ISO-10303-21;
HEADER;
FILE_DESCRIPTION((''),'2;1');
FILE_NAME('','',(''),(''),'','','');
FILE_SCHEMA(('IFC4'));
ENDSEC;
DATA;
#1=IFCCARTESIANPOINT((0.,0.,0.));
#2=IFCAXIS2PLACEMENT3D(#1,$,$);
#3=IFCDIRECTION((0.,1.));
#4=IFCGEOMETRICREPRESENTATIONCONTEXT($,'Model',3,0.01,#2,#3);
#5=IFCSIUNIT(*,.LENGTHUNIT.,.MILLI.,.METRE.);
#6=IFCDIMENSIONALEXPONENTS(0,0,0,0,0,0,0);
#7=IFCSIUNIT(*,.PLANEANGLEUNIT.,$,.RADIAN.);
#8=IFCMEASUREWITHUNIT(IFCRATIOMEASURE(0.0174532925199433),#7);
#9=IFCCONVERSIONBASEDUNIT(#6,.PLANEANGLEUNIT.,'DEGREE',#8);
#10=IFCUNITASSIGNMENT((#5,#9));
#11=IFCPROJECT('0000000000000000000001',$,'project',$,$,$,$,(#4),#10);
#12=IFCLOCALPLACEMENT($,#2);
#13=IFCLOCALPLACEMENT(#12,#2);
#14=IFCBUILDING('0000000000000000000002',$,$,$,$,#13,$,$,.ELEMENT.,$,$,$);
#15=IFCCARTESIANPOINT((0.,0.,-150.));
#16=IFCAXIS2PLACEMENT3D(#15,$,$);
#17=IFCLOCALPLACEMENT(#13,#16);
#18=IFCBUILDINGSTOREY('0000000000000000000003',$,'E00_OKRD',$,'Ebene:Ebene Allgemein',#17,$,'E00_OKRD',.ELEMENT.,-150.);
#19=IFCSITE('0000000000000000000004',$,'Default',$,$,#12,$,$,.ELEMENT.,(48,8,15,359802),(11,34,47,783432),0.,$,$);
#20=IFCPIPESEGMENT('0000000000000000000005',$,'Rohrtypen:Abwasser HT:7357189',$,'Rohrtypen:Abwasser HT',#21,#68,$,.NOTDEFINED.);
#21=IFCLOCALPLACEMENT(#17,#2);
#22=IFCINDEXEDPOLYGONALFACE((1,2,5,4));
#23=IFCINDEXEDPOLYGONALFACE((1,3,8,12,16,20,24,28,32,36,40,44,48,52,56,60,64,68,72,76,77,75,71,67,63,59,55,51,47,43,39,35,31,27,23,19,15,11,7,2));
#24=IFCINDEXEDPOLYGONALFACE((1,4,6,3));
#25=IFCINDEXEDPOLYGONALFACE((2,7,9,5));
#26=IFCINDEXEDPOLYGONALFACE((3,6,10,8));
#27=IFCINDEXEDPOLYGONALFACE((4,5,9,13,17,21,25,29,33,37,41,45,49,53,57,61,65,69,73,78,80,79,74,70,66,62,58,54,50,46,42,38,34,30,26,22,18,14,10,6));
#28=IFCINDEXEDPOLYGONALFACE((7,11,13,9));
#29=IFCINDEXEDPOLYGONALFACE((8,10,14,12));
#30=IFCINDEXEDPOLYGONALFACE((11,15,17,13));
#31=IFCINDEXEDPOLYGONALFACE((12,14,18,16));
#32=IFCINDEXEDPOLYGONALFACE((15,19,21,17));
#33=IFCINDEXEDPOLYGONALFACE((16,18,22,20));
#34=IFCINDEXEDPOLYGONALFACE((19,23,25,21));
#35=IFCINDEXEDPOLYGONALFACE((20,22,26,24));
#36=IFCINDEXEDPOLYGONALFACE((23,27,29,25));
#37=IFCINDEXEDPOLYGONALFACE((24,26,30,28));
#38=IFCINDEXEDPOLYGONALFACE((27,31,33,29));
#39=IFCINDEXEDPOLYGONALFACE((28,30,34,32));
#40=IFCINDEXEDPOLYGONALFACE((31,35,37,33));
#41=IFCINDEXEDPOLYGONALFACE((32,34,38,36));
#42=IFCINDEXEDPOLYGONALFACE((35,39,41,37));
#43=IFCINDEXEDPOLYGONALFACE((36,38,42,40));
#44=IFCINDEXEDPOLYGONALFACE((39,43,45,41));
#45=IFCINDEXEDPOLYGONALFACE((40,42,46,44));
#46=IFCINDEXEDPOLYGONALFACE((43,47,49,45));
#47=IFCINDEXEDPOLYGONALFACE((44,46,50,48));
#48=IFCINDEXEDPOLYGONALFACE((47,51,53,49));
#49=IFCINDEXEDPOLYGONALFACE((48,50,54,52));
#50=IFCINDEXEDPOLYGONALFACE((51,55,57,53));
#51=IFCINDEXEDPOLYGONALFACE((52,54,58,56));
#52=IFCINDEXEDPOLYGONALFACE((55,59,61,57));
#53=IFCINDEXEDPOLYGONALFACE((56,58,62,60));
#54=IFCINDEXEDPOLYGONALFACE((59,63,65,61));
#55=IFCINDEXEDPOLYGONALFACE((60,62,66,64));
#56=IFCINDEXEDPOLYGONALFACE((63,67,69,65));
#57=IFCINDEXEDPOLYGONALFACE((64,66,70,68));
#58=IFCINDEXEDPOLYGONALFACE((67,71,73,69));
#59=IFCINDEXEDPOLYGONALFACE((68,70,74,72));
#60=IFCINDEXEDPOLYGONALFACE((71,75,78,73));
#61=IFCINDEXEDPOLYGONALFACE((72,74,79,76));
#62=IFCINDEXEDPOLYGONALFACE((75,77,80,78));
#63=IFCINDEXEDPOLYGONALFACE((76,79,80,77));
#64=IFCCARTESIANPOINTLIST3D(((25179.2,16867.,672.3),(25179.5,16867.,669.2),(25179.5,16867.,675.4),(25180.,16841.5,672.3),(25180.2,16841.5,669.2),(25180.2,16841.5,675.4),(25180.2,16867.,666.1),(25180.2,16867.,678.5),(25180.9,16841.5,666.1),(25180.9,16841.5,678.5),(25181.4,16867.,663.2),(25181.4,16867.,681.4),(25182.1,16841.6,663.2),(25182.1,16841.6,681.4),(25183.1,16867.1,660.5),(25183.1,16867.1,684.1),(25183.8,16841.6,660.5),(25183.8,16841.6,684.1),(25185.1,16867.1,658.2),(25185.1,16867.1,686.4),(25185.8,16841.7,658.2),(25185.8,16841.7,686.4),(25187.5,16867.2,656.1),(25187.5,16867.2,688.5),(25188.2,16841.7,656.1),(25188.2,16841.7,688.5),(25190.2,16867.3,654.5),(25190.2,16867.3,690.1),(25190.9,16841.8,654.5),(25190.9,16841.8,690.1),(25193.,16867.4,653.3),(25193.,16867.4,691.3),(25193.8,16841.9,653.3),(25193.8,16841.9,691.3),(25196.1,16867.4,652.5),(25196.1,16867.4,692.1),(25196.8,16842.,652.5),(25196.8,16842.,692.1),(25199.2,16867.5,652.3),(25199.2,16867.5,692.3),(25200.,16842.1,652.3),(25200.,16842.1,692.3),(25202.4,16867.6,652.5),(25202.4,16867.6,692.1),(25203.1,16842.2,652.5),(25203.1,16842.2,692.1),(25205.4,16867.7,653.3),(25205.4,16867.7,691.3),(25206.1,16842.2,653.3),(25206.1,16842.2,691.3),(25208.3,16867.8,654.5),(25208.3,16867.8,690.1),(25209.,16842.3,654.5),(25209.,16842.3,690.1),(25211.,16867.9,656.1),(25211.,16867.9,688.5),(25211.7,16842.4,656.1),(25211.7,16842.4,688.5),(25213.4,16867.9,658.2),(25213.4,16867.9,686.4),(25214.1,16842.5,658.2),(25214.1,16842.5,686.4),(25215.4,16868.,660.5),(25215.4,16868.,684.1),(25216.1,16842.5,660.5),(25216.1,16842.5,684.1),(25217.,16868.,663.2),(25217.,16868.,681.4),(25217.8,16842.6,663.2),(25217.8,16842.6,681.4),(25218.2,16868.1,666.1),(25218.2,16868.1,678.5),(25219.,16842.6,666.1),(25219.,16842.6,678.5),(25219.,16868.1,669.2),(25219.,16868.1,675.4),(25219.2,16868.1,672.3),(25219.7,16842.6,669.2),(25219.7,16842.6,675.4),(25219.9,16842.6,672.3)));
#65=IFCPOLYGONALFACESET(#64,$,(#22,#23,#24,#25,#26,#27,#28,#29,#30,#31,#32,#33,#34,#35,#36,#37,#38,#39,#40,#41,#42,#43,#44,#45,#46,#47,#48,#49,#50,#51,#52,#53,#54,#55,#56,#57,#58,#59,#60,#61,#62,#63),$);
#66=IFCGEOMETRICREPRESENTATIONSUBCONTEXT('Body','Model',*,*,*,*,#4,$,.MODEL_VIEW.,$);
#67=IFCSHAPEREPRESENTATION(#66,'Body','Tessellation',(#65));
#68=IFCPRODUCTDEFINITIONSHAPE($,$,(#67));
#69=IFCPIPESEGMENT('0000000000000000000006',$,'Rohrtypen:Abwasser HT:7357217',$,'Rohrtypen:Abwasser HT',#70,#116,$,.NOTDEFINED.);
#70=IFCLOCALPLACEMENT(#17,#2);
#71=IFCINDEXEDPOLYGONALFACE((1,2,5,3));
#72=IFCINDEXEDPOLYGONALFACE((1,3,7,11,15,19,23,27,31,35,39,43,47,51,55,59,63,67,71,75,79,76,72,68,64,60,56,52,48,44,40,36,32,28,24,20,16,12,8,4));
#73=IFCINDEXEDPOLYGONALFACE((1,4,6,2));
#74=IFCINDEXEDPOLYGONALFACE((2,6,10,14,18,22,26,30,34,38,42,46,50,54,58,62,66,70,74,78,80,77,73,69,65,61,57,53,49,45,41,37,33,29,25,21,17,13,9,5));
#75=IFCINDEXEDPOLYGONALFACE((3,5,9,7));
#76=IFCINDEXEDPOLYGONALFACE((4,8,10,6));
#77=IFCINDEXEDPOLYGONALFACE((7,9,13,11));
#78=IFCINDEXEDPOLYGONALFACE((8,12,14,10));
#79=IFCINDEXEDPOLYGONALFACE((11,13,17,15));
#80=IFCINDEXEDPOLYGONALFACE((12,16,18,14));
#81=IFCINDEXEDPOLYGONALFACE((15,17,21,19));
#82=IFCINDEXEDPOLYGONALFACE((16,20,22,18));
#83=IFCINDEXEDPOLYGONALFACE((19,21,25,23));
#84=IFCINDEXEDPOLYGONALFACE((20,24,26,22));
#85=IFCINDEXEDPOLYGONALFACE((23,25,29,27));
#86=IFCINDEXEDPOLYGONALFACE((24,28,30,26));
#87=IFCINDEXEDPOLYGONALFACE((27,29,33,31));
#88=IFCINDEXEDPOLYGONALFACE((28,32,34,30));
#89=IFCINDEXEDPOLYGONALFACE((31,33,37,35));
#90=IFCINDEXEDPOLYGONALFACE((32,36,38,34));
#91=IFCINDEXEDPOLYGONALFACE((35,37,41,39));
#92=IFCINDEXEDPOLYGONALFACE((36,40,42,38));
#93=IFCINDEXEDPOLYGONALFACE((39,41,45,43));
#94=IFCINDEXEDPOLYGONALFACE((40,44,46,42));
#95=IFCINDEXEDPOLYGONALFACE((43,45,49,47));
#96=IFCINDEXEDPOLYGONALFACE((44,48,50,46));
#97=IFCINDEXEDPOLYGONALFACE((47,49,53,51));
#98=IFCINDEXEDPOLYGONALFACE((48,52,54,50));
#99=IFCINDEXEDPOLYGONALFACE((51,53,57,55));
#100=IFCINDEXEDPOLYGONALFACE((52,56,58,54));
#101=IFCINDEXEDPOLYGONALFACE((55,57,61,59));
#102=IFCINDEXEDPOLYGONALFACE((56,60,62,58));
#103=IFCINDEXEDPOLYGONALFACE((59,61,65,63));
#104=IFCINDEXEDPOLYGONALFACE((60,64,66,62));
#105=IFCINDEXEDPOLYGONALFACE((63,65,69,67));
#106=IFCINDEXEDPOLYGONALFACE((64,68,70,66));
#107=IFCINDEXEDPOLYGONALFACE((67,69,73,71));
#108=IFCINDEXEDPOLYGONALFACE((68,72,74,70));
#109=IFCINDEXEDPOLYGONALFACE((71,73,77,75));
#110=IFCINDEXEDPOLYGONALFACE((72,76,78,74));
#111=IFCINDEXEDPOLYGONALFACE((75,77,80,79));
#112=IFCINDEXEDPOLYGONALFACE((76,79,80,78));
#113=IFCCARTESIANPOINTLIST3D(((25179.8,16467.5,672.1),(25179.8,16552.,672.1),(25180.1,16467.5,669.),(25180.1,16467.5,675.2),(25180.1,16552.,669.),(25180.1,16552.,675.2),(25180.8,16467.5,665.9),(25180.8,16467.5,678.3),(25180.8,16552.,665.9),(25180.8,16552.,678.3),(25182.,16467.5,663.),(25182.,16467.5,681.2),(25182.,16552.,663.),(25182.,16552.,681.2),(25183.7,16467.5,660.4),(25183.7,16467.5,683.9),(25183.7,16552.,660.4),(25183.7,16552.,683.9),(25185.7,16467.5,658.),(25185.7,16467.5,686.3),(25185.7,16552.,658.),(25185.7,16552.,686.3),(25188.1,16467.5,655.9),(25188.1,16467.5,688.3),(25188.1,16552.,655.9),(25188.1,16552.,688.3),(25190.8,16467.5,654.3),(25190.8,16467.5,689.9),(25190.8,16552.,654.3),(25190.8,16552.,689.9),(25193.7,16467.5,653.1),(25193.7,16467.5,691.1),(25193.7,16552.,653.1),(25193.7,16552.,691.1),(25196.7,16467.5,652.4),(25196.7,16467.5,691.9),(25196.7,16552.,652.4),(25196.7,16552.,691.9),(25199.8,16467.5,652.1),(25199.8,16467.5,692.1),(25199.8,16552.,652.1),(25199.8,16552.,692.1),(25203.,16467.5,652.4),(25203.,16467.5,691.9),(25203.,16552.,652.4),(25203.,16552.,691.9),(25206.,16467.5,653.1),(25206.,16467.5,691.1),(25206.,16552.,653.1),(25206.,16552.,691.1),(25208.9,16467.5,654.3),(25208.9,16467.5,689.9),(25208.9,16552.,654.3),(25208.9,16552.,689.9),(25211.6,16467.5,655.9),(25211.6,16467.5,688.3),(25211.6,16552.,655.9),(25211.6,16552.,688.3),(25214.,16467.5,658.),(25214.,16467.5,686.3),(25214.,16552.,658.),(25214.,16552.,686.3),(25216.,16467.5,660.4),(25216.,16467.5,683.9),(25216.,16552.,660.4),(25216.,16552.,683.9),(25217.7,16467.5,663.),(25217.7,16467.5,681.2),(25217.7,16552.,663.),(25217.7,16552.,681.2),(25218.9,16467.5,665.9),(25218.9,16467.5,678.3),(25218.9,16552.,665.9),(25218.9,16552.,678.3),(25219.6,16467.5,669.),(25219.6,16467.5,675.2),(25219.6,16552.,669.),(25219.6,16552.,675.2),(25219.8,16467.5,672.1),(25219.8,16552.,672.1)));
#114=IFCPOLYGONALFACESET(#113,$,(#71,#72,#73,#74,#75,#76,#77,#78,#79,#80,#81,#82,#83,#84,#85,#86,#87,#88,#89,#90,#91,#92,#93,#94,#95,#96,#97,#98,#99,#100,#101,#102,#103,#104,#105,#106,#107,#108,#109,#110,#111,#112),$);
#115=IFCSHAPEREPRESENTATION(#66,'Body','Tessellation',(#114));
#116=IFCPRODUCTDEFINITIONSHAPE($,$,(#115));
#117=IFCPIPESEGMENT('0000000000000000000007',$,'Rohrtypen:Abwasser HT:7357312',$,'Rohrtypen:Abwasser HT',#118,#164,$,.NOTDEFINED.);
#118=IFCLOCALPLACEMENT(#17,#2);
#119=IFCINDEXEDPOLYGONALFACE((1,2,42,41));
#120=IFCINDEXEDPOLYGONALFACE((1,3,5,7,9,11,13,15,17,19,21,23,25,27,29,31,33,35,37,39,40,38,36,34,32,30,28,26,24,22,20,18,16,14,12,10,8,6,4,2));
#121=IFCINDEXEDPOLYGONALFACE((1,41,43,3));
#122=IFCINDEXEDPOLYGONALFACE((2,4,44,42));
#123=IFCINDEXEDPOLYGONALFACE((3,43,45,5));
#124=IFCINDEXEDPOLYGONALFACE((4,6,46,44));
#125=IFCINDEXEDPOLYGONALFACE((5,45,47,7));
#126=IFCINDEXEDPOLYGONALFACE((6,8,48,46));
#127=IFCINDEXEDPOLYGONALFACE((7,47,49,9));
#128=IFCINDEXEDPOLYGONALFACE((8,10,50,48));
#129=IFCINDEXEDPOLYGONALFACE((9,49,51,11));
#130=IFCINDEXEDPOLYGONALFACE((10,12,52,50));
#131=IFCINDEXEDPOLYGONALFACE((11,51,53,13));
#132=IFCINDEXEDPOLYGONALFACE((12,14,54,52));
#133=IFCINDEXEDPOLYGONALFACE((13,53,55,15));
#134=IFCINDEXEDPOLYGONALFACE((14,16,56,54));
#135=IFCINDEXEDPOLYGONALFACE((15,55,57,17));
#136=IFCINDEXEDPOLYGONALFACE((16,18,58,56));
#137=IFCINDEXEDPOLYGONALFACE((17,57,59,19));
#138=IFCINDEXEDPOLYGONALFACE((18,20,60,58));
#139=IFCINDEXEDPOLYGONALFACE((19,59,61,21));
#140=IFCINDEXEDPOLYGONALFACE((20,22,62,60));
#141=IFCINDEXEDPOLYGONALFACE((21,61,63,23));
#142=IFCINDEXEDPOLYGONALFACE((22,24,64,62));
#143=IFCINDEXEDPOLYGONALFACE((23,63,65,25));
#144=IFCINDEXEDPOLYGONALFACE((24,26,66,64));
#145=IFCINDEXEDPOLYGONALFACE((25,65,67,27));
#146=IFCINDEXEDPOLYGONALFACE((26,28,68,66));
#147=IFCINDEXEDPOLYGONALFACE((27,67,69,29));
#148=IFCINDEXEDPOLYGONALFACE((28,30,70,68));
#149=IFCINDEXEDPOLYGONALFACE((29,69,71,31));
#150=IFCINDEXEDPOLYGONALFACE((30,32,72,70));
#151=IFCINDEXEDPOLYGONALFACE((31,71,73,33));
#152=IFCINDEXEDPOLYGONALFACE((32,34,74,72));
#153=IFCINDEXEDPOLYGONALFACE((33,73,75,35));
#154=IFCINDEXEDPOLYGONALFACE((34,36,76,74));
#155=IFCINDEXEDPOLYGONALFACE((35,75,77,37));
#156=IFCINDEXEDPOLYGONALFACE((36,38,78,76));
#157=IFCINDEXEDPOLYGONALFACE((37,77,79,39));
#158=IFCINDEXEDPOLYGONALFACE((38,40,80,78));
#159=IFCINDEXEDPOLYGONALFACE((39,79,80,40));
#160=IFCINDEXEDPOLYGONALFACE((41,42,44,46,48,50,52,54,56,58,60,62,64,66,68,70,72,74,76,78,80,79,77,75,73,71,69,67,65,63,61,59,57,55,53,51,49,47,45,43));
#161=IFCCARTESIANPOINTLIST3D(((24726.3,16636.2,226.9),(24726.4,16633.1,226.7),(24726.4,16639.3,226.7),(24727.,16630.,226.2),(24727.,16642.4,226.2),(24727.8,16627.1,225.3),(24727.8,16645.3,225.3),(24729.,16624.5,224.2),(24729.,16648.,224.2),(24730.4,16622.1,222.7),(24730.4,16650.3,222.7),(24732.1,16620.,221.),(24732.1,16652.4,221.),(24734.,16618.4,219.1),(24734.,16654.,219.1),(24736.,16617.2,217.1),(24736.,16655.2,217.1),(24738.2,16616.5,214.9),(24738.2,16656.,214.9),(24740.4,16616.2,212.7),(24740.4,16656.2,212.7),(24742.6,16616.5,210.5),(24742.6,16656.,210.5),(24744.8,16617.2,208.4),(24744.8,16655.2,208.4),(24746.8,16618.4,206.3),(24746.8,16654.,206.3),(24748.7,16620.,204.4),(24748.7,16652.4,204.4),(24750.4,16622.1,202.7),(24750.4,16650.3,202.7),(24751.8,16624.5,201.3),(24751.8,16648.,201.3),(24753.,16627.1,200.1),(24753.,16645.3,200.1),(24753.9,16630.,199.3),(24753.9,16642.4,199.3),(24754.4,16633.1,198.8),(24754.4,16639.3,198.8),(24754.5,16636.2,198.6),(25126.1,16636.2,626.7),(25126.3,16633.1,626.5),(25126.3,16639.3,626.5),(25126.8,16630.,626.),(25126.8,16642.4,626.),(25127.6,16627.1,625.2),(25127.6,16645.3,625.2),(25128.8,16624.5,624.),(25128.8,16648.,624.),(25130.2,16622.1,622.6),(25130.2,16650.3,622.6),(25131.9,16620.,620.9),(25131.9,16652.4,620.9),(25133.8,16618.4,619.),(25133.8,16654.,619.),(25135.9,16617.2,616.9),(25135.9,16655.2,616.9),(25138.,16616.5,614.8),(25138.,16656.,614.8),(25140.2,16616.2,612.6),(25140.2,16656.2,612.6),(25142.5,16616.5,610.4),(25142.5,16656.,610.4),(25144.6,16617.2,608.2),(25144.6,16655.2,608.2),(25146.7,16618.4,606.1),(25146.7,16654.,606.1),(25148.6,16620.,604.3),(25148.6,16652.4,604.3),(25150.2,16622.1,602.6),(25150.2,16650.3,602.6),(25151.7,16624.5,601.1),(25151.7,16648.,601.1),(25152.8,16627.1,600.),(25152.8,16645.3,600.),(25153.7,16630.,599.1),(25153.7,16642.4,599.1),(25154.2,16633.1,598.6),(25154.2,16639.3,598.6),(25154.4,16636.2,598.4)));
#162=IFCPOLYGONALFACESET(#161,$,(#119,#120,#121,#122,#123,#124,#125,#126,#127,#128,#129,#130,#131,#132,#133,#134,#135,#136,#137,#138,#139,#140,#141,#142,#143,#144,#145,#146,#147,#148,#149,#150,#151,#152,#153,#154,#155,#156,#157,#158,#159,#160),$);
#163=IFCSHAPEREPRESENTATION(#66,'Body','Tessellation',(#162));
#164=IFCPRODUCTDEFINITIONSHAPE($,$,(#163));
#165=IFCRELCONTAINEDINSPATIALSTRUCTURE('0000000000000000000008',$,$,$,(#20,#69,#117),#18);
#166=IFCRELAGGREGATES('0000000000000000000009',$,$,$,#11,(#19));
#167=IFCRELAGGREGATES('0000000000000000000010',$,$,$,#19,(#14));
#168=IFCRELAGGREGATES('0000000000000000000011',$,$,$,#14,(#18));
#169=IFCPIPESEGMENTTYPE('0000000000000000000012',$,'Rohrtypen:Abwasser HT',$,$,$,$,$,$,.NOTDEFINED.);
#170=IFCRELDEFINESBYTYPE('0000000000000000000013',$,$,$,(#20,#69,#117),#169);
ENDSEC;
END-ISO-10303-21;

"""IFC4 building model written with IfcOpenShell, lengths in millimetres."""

from ifc_helpers import new_model, entity, si_unit, converted_unit, direction, frame, origin, place, context, subcontext, project, spatial, indexed_curve, outline, extrude, type_object, element, save


model = new_model("IFC4")

# Units and contexts
model_context = context("Model", 3, precision=0.01, world=origin(), true_north=direction((0.0, 1.0)))
body_context = subcontext(model_context, "Body", "Model", "MODEL_VIEW")
ifc_project = project(units=[si_unit("LENGTHUNIT", "METRE", prefix="MILLI"), converted_unit("PLANEANGLEUNIT", "DEGREE", entity("IfcRatioMeasure", 0.0174532925199433), si_unit("PLANEANGLEUNIT", "RADIAN"), dimensions=[0, 0, 0, 0, 0, 0, 0])], contexts=[model_context])

# Site, building, storey
site_placement = place(None, origin())
site = spatial("IfcSite", under=ifc_project, at=site_placement, Name="Default", CompositionType="ELEMENT", RefLatitude=(48, 8, 15, 359802), RefLongitude=(11, 34, 47, 783432), RefElevation=0.0)
building_placement = place(site_placement, origin())
building = spatial("IfcBuilding", under=site, at=building_placement, CompositionType="ELEMENT")
storey_placement = place(building_placement, frame((0.0, 0.0, -150.0)))
storey = spatial("IfcBuildingStorey", under=building, at=storey_placement, Name="E00_OKRD", ObjectType="Ebene:Ebene Allgemein", LongName="E00_OKRD", CompositionType="ELEMENT", Elevation=-150.0)

# Pipe segments
pipe_segment_type_1 = type_object("IfcPipeSegmentType", Name="Rohrtypen:Abwasser HT", PredefinedType="NOTDEFINED")
pipe_segment_1_placement = place(storey_placement, origin())
element("IfcPipeSegment", 1, at=pipe_segment_1_placement, inside=storey, type_object=pipe_segment_type_1, Name="Rohrtypen:Abwasser HT:7357189", ObjectType="Rohrtypen:Abwasser HT", PredefinedType="NOTDEFINED", context=body_context, shape_type="SweptSolid", body=[
    extrude(outline(indexed_curve([(20.0, 0.0), (19.8, 3.1), (19.0, 6.2), (17.8, 9.1), (16.2, 11.8), (14.1, 14.1), (11.8, 16.2), (9.1, 17.8), (6.2, 19.0), (3.1, 19.8), (0.0, 20.0), (-3.1, 19.8), (-6.2, 19.0), (-9.1, 17.8), (-11.8, 16.2), (-14.1, 14.1), (-16.2, 11.8), (-17.8, 9.1), (-19.0, 6.2), (-19.8, 3.1), (-20.0, 0.0), (-19.8, -3.1), (-19.0, -6.2), (-17.8, -9.1), (-16.2, -11.8), (-14.1, -14.1), (-11.8, -16.2), (-9.1, -17.8), (-6.2, -19.0), (-3.1, -19.8), (0.0, -20.0), (3.1, -19.8), (6.2, -19.0), (9.1, -17.8), (11.8, -16.2), (14.1, -14.1), (16.2, -11.8), (17.8, -9.1), (19.0, -6.2), (19.8, -3.1), (20.0, 0.0)], self_intersect=False)), frame((25199.2, 16867.5, 672.3), z_axis=(0.02857, -0.999592, 0.0), x_axis=(-0.999592, -0.02857, 0.0)), (0.0, 0.0, 1.0), 25.5),
])
pipe_segment_2_placement = place(storey_placement, origin())
element("IfcPipeSegment", 2, at=pipe_segment_2_placement, inside=storey, type_object=pipe_segment_type_1, Name="Rohrtypen:Abwasser HT:7357217", ObjectType="Rohrtypen:Abwasser HT", PredefinedType="NOTDEFINED", context=body_context, shape_type="SweptSolid", body=[
    extrude(outline(indexed_curve([(20.0, 0.0), (19.8, 3.1), (19.0, 6.2), (17.8, 9.1), (16.2, 11.8), (14.1, 14.1), (11.8, 16.2), (9.1, 17.8), (6.2, 19.0), (3.1, 19.8), (0.0, 20.0), (-3.1, 19.8), (-6.2, 19.0), (-9.1, 17.8), (-11.8, 16.2), (-14.1, 14.1), (-16.2, 11.8), (-17.8, 9.1), (-19.0, 6.2), (-19.8, 3.1), (-20.0, 0.0), (-19.8, -3.1), (-19.0, -6.2), (-17.8, -9.1), (-16.2, -11.8), (-14.1, -14.1), (-11.8, -16.2), (-9.1, -17.8), (-6.2, -19.0), (-3.1, -19.8), (0.0, -20.0), (3.1, -19.8), (6.2, -19.0), (9.1, -17.8), (11.8, -16.2), (14.1, -14.1), (16.2, -11.8), (17.8, -9.1), (19.0, -6.2), (19.8, -3.1), (20.0, 0.0)], self_intersect=False)), frame((25199.8, 16467.5, 672.1), z_axis=(0.000043, 1.0, 0.0), x_axis=(1.0, -0.000043, 0.0)), (0.0, 0.0, 1.0), 84.4),
])
pipe_segment_3_placement = place(storey_placement, origin())
element("IfcPipeSegment", 3, at=pipe_segment_3_placement, inside=storey, type_object=pipe_segment_type_1, Name="Rohrtypen:Abwasser HT:7357312", ObjectType="Rohrtypen:Abwasser HT", PredefinedType="NOTDEFINED", context=body_context, shape_type="SweptSolid", body=[
    extrude(outline(indexed_curve([(20.0, 0.0), (19.8, 3.1), (19.0, 6.2), (17.8, 9.1), (16.2, 11.8), (14.1, 14.1), (11.8, 16.2), (9.1, 17.8), (6.2, 19.0), (3.1, 19.8), (0.0, 20.0), (-3.1, 19.8), (-6.2, 19.0), (-9.1, 17.8), (-11.8, 16.2), (-14.1, 14.1), (-16.2, 11.8), (-17.8, 9.1), (-19.0, 6.2), (-19.8, 3.1), (-20.0, 0.0), (-19.8, -3.1), (-19.0, -6.2), (-17.8, -9.1), (-16.2, -11.8), (-14.1, -14.1), (-11.8, -16.2), (-9.1, -17.8), (-6.2, -19.0), (-3.1, -19.8), (0.0, -20.0), (3.1, -19.8), (6.2, -19.0), (9.1, -17.8), (11.8, -16.2), (14.1, -14.1), (16.2, -11.8), (17.8, -9.1), (19.0, -6.2), (19.8, -3.1), (20.0, 0.0)], self_intersect=False)), frame((24740.4, 16636.2, 212.7), z_axis=(0.707107, 0.0, 0.707107), x_axis=(0.0, -1.0, 0.0)), (0.0, 0.0, 1.0), 565.5),
])

save(model, "model.ifc")
